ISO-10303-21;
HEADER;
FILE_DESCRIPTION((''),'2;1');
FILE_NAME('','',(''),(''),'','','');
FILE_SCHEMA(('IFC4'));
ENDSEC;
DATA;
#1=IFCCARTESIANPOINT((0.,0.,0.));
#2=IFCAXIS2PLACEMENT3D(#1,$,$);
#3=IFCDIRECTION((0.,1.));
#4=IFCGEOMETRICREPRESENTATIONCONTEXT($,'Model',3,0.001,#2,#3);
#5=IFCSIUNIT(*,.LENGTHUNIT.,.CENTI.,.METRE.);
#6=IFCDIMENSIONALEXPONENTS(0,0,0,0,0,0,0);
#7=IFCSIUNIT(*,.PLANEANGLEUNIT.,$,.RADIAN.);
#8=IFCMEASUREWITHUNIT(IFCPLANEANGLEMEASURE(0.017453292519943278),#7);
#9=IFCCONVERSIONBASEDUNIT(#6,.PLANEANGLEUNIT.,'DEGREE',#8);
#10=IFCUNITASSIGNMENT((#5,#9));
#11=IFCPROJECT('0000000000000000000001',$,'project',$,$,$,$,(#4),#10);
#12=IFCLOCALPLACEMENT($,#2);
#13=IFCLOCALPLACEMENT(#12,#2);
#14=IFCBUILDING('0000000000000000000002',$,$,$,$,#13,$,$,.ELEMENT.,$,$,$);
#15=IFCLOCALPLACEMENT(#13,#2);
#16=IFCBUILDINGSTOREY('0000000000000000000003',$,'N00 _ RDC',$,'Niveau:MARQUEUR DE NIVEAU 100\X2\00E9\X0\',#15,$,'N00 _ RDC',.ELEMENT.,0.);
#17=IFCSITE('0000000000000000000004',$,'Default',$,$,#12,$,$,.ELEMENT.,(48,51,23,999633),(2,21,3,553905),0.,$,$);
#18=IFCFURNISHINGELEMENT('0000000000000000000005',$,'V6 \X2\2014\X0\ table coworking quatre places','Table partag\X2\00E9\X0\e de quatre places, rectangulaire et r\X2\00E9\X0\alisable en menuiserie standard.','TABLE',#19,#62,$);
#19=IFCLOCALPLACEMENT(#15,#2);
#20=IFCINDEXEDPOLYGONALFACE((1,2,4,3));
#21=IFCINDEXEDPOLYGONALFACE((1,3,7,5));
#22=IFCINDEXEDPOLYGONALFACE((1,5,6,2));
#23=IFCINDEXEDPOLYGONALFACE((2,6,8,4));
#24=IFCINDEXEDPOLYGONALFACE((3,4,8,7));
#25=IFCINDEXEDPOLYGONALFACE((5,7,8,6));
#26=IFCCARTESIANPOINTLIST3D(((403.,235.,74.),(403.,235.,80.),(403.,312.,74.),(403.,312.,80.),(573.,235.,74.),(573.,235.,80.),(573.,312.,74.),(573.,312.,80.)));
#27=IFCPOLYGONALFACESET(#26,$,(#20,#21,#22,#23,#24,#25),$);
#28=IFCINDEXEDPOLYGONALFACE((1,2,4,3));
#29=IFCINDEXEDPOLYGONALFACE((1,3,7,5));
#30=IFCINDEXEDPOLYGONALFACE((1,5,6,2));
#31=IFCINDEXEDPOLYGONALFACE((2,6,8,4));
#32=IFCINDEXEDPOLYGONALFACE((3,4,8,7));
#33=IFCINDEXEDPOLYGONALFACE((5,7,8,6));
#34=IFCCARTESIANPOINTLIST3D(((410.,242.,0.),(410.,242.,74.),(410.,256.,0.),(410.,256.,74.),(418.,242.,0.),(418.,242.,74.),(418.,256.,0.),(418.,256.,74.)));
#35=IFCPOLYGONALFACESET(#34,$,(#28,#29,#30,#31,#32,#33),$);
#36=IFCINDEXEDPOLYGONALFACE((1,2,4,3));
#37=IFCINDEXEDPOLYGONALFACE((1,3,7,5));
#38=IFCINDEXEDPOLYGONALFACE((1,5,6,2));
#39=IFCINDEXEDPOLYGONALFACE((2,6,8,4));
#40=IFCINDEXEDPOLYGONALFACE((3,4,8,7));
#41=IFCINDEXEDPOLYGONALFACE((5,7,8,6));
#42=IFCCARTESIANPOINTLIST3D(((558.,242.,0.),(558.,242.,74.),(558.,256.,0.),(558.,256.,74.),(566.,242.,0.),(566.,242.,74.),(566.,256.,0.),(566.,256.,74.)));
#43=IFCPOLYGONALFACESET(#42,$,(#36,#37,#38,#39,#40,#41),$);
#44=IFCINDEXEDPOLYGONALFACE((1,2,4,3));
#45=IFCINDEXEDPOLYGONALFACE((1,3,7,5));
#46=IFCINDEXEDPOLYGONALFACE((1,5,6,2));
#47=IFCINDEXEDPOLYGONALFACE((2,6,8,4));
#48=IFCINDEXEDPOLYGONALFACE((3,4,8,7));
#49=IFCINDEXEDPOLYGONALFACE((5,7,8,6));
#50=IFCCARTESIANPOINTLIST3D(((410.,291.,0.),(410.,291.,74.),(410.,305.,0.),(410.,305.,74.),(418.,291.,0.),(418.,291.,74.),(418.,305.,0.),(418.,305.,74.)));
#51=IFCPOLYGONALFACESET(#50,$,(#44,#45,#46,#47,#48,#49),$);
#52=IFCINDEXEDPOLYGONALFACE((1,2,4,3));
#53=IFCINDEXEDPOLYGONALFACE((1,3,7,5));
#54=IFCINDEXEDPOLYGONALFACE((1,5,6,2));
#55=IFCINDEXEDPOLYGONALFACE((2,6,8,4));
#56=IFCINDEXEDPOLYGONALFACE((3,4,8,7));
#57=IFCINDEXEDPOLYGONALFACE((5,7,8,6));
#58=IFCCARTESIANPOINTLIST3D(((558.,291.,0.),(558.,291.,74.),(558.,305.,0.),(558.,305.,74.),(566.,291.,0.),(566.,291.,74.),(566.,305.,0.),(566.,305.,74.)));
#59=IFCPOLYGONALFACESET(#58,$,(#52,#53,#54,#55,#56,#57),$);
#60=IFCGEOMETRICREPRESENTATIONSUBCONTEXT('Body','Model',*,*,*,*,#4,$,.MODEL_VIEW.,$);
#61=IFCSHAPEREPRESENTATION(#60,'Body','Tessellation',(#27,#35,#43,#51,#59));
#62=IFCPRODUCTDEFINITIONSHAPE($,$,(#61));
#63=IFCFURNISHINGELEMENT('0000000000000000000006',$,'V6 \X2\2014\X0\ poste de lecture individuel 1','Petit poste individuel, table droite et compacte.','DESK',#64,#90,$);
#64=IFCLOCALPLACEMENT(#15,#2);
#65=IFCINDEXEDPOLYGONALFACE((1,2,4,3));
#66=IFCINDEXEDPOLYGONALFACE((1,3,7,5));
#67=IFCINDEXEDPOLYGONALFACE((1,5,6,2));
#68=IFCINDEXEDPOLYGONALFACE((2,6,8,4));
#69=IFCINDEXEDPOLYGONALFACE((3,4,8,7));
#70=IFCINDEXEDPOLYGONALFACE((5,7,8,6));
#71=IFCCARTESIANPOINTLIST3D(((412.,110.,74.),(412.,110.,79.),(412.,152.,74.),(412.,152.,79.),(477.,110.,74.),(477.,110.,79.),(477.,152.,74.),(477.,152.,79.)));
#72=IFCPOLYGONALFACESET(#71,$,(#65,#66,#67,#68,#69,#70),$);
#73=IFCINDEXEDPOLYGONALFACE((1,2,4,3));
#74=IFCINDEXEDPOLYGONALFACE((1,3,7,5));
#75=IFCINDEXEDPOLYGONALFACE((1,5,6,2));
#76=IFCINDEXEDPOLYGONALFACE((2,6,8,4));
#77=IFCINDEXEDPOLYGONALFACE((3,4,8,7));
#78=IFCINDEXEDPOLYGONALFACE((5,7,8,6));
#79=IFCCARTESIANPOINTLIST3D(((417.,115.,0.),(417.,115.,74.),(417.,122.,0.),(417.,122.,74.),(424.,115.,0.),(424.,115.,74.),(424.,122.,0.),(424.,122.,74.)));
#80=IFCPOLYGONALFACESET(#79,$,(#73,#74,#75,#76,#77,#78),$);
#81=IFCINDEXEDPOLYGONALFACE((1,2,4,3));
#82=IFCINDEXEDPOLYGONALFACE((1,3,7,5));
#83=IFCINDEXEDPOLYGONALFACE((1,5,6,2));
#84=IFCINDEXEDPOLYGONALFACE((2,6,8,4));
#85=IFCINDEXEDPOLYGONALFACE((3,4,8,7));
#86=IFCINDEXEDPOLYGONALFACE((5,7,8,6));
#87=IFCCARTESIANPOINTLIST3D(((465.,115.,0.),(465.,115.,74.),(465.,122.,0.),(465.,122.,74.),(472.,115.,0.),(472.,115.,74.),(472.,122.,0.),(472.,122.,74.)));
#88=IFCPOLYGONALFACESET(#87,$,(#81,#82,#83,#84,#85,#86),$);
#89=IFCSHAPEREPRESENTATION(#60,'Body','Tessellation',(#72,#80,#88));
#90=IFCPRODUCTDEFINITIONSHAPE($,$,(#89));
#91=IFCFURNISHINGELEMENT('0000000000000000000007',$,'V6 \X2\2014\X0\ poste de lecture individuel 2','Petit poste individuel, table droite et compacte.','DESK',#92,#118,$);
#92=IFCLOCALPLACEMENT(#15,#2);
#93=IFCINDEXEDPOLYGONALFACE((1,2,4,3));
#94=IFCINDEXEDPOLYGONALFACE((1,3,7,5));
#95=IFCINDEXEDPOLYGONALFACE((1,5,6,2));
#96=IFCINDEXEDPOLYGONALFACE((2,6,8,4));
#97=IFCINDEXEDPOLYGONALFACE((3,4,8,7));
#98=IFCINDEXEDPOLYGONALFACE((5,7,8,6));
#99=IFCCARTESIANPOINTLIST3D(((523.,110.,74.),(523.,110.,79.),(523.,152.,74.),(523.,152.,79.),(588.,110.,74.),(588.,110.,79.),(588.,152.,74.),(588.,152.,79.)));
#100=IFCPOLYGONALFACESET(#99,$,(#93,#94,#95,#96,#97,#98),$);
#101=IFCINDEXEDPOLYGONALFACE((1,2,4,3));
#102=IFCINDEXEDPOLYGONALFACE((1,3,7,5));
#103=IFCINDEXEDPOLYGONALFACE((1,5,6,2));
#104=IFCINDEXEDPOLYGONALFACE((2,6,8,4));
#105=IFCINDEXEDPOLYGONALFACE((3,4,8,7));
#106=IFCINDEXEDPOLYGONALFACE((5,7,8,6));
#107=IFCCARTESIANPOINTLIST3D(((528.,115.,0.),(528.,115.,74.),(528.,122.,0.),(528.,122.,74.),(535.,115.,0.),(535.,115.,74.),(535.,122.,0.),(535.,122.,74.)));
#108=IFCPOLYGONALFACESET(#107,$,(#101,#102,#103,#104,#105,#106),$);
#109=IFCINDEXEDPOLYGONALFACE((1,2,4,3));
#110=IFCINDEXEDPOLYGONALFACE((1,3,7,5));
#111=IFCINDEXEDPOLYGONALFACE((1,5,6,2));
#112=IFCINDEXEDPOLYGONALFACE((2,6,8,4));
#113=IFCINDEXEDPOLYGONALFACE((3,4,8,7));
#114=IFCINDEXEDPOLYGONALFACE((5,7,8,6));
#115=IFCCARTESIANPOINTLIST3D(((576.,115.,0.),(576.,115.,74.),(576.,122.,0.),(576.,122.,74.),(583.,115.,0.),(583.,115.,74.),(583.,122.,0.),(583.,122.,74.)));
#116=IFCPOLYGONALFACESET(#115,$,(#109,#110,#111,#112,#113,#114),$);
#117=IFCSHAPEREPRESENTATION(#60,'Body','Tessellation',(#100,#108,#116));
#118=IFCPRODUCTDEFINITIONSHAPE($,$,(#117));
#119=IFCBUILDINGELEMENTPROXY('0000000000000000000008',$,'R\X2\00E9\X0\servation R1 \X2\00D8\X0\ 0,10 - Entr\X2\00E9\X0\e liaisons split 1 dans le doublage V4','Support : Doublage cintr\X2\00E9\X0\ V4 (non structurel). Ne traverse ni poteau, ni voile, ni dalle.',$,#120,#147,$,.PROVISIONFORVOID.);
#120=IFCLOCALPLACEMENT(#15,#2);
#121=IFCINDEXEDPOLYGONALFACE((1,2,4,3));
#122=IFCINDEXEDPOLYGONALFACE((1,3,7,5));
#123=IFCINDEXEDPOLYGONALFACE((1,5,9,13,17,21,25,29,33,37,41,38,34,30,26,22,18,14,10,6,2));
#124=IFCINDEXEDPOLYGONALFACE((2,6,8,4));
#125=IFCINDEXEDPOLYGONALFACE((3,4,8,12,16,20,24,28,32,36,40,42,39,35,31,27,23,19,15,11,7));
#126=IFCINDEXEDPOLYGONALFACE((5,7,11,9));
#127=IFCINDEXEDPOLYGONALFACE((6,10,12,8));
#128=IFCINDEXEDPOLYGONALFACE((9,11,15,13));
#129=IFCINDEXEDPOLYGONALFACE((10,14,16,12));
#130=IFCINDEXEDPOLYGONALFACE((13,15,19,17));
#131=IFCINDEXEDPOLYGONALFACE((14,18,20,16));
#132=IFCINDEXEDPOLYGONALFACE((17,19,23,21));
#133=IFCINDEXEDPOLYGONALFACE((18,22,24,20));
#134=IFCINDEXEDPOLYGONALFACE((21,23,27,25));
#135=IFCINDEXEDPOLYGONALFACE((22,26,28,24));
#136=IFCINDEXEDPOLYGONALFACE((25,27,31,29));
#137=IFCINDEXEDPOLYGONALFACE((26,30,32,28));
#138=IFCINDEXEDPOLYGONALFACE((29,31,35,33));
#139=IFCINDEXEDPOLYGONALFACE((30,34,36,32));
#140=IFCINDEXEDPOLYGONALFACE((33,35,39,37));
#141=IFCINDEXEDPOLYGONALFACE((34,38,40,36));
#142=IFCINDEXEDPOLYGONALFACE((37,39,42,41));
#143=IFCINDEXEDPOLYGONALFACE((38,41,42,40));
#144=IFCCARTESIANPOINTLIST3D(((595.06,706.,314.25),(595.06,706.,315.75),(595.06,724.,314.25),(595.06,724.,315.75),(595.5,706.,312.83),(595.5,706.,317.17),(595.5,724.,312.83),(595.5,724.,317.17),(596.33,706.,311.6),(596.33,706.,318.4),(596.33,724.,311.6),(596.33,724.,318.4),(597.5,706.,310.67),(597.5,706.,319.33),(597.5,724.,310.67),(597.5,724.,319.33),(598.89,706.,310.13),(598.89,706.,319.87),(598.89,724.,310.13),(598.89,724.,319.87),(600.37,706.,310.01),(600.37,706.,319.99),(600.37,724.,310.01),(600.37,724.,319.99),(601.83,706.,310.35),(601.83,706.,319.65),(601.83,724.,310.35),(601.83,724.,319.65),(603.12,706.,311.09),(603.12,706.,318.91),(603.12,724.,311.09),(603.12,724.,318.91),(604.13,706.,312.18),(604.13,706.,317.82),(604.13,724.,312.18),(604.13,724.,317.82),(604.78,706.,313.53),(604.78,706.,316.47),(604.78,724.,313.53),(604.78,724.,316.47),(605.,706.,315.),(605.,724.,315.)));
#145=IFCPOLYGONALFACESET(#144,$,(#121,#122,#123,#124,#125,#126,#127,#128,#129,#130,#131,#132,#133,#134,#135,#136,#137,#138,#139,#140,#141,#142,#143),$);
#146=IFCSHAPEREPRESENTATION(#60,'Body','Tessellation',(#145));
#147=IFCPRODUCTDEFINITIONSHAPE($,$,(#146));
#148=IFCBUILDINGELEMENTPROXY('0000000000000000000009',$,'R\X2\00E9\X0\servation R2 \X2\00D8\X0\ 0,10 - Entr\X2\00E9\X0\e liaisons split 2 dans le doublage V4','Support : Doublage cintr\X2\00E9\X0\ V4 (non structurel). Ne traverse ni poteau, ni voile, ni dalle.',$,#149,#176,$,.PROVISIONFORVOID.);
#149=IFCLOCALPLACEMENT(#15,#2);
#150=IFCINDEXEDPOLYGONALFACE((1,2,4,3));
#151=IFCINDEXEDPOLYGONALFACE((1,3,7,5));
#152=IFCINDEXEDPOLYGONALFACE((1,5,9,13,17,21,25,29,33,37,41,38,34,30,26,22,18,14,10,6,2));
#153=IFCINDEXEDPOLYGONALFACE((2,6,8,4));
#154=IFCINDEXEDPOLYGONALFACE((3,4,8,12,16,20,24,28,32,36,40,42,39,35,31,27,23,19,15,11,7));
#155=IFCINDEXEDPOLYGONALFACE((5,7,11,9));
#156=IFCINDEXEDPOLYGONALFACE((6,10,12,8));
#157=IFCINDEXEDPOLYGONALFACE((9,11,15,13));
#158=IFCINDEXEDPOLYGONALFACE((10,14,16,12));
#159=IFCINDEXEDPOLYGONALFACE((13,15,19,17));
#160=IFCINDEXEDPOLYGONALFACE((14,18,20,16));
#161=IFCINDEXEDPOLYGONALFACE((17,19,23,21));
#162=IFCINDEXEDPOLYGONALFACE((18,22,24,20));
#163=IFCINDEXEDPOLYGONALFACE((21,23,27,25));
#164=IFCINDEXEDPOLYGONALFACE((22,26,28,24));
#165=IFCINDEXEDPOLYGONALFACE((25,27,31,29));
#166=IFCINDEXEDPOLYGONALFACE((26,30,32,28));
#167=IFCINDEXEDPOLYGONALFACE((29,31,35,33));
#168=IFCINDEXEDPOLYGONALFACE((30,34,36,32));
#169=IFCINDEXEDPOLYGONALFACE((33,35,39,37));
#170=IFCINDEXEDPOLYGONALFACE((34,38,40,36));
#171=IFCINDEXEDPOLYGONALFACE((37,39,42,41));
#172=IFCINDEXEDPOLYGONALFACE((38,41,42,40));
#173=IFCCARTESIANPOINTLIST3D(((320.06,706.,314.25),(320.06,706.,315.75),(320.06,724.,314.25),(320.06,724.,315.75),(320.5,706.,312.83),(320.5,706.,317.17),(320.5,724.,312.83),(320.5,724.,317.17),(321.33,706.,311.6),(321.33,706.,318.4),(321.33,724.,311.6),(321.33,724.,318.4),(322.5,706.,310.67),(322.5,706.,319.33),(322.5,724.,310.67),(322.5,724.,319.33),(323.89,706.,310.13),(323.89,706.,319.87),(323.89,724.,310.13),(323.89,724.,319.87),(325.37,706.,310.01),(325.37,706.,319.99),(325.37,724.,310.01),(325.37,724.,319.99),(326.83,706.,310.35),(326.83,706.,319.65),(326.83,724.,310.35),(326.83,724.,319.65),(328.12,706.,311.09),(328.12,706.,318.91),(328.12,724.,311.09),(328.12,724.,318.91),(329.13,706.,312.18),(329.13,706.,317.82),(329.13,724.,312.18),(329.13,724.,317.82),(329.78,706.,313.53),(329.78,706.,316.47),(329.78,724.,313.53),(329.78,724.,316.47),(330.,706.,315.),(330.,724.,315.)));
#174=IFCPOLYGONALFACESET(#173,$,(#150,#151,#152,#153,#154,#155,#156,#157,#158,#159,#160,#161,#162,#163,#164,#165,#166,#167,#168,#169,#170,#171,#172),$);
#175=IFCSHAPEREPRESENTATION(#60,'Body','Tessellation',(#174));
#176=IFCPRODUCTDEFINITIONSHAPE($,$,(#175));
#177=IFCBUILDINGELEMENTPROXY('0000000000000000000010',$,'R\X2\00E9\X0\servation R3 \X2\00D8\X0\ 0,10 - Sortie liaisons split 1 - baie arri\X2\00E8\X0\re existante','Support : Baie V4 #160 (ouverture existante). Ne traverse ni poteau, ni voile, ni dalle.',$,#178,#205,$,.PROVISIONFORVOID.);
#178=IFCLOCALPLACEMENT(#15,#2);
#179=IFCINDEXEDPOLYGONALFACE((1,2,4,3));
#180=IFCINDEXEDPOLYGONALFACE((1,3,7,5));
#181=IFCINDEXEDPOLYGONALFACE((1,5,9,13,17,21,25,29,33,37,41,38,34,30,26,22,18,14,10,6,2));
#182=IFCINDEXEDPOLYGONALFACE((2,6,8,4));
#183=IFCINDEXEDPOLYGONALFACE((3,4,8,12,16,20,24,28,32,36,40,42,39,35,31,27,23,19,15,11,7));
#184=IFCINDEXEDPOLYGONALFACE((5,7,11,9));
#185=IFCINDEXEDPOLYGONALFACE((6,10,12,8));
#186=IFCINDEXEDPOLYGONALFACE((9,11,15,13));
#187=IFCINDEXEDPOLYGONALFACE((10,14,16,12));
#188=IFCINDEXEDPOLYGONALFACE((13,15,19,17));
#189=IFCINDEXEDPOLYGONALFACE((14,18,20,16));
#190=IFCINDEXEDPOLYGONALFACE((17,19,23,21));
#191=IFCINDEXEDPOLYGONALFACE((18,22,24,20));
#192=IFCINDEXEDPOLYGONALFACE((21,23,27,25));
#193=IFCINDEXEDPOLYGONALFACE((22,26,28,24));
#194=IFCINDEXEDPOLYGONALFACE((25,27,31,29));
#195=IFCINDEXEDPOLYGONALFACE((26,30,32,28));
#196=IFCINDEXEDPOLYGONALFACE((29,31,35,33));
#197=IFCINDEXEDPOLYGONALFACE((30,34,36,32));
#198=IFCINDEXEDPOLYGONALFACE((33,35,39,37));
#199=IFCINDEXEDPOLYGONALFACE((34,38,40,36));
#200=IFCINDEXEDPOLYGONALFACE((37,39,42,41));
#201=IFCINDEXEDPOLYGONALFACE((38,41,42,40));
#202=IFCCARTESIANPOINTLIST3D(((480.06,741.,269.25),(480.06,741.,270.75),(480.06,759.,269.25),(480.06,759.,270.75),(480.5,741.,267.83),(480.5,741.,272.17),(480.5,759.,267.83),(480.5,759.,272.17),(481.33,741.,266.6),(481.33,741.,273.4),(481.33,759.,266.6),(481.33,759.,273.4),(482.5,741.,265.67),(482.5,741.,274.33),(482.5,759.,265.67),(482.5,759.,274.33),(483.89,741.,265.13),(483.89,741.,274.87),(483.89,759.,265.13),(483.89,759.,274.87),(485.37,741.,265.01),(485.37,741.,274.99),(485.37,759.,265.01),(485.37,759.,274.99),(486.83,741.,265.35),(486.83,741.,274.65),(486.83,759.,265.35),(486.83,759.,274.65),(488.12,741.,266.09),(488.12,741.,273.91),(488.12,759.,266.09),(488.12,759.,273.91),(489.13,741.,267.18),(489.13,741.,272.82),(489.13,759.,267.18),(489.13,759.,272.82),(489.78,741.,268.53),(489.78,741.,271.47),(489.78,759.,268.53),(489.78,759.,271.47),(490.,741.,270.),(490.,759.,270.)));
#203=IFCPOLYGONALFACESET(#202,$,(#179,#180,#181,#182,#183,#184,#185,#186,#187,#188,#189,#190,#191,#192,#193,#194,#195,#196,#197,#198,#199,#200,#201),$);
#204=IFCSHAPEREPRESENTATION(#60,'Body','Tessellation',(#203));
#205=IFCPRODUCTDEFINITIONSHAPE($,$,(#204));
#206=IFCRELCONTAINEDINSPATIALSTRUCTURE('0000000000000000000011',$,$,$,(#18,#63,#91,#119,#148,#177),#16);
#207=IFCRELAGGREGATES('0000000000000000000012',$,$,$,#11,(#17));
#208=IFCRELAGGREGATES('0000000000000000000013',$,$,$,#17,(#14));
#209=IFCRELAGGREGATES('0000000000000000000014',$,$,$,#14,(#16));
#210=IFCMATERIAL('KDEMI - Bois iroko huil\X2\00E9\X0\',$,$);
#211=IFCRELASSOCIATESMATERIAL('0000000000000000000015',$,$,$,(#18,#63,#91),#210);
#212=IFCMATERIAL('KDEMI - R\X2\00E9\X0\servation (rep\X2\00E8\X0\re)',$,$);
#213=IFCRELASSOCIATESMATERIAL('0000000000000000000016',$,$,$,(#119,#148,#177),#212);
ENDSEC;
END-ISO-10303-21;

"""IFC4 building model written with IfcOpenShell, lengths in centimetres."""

from ifc_helpers import new_model, entity, si_unit, converted_unit, direction, frame, frame_2d, origin, origin_with_axes, origin_2d, place, context, subcontext, project, spatial, rectangle, circle, extrude, material, element, save


model = new_model("IFC4")

# Units and contexts
model_context = context("Model", 3, precision=0.001, world=origin(), true_north=direction((0.0, 1.0)))
body_context = subcontext(model_context, "Body", "Model", "MODEL_VIEW")
ifc_project = project(units=[si_unit("LENGTHUNIT", "METRE", prefix="CENTI"), converted_unit("PLANEANGLEUNIT", "DEGREE", entity("IfcPlaneAngleMeasure", 0.017453292519943278), si_unit("PLANEANGLEUNIT", "RADIAN"), dimensions=[0, 0, 0, 0, 0, 0, 0])], contexts=[model_context])

# Site, building, storey
site_placement = place(None, origin())
site = spatial("IfcSite", under=ifc_project, at=site_placement, Name="Default", CompositionType="ELEMENT", RefLatitude=(48, 51, 23, 999633), RefLongitude=(2, 21, 3, 553905), RefElevation=0.0)
building_placement = place(site_placement, origin())
building = spatial("IfcBuilding", under=site, at=building_placement, CompositionType="ELEMENT")
storey_placement = place(building_placement, origin())
storey = spatial("IfcBuildingStorey", under=building, at=storey_placement, Name="N00 _ RDC", ObjectType="Niveau:MARQUEUR DE NIVEAU 100é", LongName="N00 _ RDC", CompositionType="ELEMENT", Elevation=0.0)

# Furnishing elements
ifc_material_1 = material(Name="KDEMI - Bois iroko huilé")
furnishing_1_placement = place(storey_placement, origin_with_axes())
element("IfcFurnishingElement", 1, at=furnishing_1_placement, inside=storey, material=ifc_material_1, Name="V6 — table coworking quatre places", Description="Table partagée de quatre places, rectangulaire et réalisable en menuiserie standard.", ObjectType="TABLE", context=body_context, shape_type="SweptSolid", body=[
    extrude(rectangle(XDim=170.0, YDim=77.0, at=frame_2d((488.0, 273.5))), frame((0.0, 0.0, 74.0)), (0.0, 0.0, 1.0), 6.0),
    extrude(rectangle(XDim=8.0, YDim=14.0, at=frame_2d((414.0, 249.0))), origin(), (0.0, 0.0, 1.0), 74.0),
    extrude(rectangle(XDim=8.0, YDim=14.0, at=frame_2d((562.0, 249.0))), origin(), (0.0, 0.0, 1.0), 74.0),
    extrude(rectangle(XDim=8.0, YDim=14.0, at=frame_2d((414.0, 298.0))), origin(), (0.0, 0.0, 1.0), 74.0),
    extrude(rectangle(XDim=8.0, YDim=14.0, at=frame_2d((562.0, 298.0))), origin(), (0.0, 0.0, 1.0), 74.0),
])
furnishing_2_placement = place(storey_placement, origin_with_axes())
element("IfcFurnishingElement", 2, at=furnishing_2_placement, inside=storey, material=ifc_material_1, Name="V6 — poste de lecture individuel 1", Description="Petit poste individuel, table droite et compacte.", ObjectType="DESK", context=body_context, shape_type="SweptSolid", body=[
    extrude(rectangle(XDim=65.0, YDim=42.0, at=frame_2d((444.5, 131.0))), frame((0.0, 0.0, 74.0)), (0.0, 0.0, 1.0), 5.0),
    extrude(rectangle(XDim=7.0, YDim=7.0, at=frame_2d((420.5, 118.5))), origin(), (0.0, 0.0, 1.0), 74.0),
    extrude(rectangle(XDim=7.0, YDim=7.0, at=frame_2d((468.5, 118.5))), origin(), (0.0, 0.0, 1.0), 74.0),
])
furnishing_3_placement = place(storey_placement, origin_with_axes())
element("IfcFurnishingElement", 3, at=furnishing_3_placement, inside=storey, material=ifc_material_1, Name="V6 — poste de lecture individuel 2", Description="Petit poste individuel, table droite et compacte.", ObjectType="DESK", context=body_context, shape_type="SweptSolid", body=[
    extrude(rectangle(XDim=65.0, YDim=42.0, at=frame_2d((555.5, 131.0))), frame((0.0, 0.0, 74.0)), (0.0, 0.0, 1.0), 5.0),
    extrude(rectangle(XDim=7.0, YDim=7.0, at=frame_2d((531.5, 118.5))), origin(), (0.0, 0.0, 1.0), 74.0),
    extrude(rectangle(XDim=7.0, YDim=7.0, at=frame_2d((579.5, 118.5))), origin(), (0.0, 0.0, 1.0), 74.0),
])

# Building element proxies
ifc_material_2 = material(Name="KDEMI - Réservation (repère)")
proxy_1_placement = place(storey_placement, origin_with_axes())
element("IfcBuildingElementProxy", 4, at=proxy_1_placement, inside=storey, material=ifc_material_2, Name="Réservation R1 Ø 0,10 - Entrée liaisons split 1 dans le doublage V4", Description="Support : Doublage cintré V4 (non structurel). Ne traverse ni poteau, ni voile, ni dalle.", PredefinedType="PROVISIONFORVOID", context=body_context, shape_type="SweptSolid", body=[
    extrude(circle(Radius=5.0, at=origin_2d()), frame((600.0, 706.0, 315.0), z_axis=(0.0, 1.0, 0.0), x_axis=(1.0, 0.0, 0.0)), (0.0, 0.0, 1.0), 18.0),
])
proxy_2_placement = place(storey_placement, origin_with_axes())
element("IfcBuildingElementProxy", 5, at=proxy_2_placement, inside=storey, material=ifc_material_2, Name="Réservation R2 Ø 0,10 - Entrée liaisons split 2 dans le doublage V4", Description="Support : Doublage cintré V4 (non structurel). Ne traverse ni poteau, ni voile, ni dalle.", PredefinedType="PROVISIONFORVOID", context=body_context, shape_type="SweptSolid", body=[
    extrude(circle(Radius=5.0, at=origin_2d()), frame((325.0, 706.0, 315.0), z_axis=(0.0, 1.0, 0.0), x_axis=(1.0, 0.0, 0.0)), (0.0, 0.0, 1.0), 18.0),
])
proxy_3_placement = place(storey_placement, origin_with_axes())
element("IfcBuildingElementProxy", 6, at=proxy_3_placement, inside=storey, material=ifc_material_2, Name="Réservation R3 Ø 0,10 - Sortie liaisons split 1 - baie arrière existante", Description="Support : Baie V4 #160 (ouverture existante). Ne traverse ni poteau, ni voile, ni dalle.", PredefinedType="PROVISIONFORVOID", context=body_context, shape_type="SweptSolid", body=[
    extrude(circle(Radius=5.0, at=origin_2d()), frame((485.0, 741.0, 270.0), z_axis=(0.0, 1.0, 0.0), x_axis=(1.0, 0.0, 0.0)), (0.0, 0.0, 1.0), 18.0),
])

save(model, "model.ifc")
